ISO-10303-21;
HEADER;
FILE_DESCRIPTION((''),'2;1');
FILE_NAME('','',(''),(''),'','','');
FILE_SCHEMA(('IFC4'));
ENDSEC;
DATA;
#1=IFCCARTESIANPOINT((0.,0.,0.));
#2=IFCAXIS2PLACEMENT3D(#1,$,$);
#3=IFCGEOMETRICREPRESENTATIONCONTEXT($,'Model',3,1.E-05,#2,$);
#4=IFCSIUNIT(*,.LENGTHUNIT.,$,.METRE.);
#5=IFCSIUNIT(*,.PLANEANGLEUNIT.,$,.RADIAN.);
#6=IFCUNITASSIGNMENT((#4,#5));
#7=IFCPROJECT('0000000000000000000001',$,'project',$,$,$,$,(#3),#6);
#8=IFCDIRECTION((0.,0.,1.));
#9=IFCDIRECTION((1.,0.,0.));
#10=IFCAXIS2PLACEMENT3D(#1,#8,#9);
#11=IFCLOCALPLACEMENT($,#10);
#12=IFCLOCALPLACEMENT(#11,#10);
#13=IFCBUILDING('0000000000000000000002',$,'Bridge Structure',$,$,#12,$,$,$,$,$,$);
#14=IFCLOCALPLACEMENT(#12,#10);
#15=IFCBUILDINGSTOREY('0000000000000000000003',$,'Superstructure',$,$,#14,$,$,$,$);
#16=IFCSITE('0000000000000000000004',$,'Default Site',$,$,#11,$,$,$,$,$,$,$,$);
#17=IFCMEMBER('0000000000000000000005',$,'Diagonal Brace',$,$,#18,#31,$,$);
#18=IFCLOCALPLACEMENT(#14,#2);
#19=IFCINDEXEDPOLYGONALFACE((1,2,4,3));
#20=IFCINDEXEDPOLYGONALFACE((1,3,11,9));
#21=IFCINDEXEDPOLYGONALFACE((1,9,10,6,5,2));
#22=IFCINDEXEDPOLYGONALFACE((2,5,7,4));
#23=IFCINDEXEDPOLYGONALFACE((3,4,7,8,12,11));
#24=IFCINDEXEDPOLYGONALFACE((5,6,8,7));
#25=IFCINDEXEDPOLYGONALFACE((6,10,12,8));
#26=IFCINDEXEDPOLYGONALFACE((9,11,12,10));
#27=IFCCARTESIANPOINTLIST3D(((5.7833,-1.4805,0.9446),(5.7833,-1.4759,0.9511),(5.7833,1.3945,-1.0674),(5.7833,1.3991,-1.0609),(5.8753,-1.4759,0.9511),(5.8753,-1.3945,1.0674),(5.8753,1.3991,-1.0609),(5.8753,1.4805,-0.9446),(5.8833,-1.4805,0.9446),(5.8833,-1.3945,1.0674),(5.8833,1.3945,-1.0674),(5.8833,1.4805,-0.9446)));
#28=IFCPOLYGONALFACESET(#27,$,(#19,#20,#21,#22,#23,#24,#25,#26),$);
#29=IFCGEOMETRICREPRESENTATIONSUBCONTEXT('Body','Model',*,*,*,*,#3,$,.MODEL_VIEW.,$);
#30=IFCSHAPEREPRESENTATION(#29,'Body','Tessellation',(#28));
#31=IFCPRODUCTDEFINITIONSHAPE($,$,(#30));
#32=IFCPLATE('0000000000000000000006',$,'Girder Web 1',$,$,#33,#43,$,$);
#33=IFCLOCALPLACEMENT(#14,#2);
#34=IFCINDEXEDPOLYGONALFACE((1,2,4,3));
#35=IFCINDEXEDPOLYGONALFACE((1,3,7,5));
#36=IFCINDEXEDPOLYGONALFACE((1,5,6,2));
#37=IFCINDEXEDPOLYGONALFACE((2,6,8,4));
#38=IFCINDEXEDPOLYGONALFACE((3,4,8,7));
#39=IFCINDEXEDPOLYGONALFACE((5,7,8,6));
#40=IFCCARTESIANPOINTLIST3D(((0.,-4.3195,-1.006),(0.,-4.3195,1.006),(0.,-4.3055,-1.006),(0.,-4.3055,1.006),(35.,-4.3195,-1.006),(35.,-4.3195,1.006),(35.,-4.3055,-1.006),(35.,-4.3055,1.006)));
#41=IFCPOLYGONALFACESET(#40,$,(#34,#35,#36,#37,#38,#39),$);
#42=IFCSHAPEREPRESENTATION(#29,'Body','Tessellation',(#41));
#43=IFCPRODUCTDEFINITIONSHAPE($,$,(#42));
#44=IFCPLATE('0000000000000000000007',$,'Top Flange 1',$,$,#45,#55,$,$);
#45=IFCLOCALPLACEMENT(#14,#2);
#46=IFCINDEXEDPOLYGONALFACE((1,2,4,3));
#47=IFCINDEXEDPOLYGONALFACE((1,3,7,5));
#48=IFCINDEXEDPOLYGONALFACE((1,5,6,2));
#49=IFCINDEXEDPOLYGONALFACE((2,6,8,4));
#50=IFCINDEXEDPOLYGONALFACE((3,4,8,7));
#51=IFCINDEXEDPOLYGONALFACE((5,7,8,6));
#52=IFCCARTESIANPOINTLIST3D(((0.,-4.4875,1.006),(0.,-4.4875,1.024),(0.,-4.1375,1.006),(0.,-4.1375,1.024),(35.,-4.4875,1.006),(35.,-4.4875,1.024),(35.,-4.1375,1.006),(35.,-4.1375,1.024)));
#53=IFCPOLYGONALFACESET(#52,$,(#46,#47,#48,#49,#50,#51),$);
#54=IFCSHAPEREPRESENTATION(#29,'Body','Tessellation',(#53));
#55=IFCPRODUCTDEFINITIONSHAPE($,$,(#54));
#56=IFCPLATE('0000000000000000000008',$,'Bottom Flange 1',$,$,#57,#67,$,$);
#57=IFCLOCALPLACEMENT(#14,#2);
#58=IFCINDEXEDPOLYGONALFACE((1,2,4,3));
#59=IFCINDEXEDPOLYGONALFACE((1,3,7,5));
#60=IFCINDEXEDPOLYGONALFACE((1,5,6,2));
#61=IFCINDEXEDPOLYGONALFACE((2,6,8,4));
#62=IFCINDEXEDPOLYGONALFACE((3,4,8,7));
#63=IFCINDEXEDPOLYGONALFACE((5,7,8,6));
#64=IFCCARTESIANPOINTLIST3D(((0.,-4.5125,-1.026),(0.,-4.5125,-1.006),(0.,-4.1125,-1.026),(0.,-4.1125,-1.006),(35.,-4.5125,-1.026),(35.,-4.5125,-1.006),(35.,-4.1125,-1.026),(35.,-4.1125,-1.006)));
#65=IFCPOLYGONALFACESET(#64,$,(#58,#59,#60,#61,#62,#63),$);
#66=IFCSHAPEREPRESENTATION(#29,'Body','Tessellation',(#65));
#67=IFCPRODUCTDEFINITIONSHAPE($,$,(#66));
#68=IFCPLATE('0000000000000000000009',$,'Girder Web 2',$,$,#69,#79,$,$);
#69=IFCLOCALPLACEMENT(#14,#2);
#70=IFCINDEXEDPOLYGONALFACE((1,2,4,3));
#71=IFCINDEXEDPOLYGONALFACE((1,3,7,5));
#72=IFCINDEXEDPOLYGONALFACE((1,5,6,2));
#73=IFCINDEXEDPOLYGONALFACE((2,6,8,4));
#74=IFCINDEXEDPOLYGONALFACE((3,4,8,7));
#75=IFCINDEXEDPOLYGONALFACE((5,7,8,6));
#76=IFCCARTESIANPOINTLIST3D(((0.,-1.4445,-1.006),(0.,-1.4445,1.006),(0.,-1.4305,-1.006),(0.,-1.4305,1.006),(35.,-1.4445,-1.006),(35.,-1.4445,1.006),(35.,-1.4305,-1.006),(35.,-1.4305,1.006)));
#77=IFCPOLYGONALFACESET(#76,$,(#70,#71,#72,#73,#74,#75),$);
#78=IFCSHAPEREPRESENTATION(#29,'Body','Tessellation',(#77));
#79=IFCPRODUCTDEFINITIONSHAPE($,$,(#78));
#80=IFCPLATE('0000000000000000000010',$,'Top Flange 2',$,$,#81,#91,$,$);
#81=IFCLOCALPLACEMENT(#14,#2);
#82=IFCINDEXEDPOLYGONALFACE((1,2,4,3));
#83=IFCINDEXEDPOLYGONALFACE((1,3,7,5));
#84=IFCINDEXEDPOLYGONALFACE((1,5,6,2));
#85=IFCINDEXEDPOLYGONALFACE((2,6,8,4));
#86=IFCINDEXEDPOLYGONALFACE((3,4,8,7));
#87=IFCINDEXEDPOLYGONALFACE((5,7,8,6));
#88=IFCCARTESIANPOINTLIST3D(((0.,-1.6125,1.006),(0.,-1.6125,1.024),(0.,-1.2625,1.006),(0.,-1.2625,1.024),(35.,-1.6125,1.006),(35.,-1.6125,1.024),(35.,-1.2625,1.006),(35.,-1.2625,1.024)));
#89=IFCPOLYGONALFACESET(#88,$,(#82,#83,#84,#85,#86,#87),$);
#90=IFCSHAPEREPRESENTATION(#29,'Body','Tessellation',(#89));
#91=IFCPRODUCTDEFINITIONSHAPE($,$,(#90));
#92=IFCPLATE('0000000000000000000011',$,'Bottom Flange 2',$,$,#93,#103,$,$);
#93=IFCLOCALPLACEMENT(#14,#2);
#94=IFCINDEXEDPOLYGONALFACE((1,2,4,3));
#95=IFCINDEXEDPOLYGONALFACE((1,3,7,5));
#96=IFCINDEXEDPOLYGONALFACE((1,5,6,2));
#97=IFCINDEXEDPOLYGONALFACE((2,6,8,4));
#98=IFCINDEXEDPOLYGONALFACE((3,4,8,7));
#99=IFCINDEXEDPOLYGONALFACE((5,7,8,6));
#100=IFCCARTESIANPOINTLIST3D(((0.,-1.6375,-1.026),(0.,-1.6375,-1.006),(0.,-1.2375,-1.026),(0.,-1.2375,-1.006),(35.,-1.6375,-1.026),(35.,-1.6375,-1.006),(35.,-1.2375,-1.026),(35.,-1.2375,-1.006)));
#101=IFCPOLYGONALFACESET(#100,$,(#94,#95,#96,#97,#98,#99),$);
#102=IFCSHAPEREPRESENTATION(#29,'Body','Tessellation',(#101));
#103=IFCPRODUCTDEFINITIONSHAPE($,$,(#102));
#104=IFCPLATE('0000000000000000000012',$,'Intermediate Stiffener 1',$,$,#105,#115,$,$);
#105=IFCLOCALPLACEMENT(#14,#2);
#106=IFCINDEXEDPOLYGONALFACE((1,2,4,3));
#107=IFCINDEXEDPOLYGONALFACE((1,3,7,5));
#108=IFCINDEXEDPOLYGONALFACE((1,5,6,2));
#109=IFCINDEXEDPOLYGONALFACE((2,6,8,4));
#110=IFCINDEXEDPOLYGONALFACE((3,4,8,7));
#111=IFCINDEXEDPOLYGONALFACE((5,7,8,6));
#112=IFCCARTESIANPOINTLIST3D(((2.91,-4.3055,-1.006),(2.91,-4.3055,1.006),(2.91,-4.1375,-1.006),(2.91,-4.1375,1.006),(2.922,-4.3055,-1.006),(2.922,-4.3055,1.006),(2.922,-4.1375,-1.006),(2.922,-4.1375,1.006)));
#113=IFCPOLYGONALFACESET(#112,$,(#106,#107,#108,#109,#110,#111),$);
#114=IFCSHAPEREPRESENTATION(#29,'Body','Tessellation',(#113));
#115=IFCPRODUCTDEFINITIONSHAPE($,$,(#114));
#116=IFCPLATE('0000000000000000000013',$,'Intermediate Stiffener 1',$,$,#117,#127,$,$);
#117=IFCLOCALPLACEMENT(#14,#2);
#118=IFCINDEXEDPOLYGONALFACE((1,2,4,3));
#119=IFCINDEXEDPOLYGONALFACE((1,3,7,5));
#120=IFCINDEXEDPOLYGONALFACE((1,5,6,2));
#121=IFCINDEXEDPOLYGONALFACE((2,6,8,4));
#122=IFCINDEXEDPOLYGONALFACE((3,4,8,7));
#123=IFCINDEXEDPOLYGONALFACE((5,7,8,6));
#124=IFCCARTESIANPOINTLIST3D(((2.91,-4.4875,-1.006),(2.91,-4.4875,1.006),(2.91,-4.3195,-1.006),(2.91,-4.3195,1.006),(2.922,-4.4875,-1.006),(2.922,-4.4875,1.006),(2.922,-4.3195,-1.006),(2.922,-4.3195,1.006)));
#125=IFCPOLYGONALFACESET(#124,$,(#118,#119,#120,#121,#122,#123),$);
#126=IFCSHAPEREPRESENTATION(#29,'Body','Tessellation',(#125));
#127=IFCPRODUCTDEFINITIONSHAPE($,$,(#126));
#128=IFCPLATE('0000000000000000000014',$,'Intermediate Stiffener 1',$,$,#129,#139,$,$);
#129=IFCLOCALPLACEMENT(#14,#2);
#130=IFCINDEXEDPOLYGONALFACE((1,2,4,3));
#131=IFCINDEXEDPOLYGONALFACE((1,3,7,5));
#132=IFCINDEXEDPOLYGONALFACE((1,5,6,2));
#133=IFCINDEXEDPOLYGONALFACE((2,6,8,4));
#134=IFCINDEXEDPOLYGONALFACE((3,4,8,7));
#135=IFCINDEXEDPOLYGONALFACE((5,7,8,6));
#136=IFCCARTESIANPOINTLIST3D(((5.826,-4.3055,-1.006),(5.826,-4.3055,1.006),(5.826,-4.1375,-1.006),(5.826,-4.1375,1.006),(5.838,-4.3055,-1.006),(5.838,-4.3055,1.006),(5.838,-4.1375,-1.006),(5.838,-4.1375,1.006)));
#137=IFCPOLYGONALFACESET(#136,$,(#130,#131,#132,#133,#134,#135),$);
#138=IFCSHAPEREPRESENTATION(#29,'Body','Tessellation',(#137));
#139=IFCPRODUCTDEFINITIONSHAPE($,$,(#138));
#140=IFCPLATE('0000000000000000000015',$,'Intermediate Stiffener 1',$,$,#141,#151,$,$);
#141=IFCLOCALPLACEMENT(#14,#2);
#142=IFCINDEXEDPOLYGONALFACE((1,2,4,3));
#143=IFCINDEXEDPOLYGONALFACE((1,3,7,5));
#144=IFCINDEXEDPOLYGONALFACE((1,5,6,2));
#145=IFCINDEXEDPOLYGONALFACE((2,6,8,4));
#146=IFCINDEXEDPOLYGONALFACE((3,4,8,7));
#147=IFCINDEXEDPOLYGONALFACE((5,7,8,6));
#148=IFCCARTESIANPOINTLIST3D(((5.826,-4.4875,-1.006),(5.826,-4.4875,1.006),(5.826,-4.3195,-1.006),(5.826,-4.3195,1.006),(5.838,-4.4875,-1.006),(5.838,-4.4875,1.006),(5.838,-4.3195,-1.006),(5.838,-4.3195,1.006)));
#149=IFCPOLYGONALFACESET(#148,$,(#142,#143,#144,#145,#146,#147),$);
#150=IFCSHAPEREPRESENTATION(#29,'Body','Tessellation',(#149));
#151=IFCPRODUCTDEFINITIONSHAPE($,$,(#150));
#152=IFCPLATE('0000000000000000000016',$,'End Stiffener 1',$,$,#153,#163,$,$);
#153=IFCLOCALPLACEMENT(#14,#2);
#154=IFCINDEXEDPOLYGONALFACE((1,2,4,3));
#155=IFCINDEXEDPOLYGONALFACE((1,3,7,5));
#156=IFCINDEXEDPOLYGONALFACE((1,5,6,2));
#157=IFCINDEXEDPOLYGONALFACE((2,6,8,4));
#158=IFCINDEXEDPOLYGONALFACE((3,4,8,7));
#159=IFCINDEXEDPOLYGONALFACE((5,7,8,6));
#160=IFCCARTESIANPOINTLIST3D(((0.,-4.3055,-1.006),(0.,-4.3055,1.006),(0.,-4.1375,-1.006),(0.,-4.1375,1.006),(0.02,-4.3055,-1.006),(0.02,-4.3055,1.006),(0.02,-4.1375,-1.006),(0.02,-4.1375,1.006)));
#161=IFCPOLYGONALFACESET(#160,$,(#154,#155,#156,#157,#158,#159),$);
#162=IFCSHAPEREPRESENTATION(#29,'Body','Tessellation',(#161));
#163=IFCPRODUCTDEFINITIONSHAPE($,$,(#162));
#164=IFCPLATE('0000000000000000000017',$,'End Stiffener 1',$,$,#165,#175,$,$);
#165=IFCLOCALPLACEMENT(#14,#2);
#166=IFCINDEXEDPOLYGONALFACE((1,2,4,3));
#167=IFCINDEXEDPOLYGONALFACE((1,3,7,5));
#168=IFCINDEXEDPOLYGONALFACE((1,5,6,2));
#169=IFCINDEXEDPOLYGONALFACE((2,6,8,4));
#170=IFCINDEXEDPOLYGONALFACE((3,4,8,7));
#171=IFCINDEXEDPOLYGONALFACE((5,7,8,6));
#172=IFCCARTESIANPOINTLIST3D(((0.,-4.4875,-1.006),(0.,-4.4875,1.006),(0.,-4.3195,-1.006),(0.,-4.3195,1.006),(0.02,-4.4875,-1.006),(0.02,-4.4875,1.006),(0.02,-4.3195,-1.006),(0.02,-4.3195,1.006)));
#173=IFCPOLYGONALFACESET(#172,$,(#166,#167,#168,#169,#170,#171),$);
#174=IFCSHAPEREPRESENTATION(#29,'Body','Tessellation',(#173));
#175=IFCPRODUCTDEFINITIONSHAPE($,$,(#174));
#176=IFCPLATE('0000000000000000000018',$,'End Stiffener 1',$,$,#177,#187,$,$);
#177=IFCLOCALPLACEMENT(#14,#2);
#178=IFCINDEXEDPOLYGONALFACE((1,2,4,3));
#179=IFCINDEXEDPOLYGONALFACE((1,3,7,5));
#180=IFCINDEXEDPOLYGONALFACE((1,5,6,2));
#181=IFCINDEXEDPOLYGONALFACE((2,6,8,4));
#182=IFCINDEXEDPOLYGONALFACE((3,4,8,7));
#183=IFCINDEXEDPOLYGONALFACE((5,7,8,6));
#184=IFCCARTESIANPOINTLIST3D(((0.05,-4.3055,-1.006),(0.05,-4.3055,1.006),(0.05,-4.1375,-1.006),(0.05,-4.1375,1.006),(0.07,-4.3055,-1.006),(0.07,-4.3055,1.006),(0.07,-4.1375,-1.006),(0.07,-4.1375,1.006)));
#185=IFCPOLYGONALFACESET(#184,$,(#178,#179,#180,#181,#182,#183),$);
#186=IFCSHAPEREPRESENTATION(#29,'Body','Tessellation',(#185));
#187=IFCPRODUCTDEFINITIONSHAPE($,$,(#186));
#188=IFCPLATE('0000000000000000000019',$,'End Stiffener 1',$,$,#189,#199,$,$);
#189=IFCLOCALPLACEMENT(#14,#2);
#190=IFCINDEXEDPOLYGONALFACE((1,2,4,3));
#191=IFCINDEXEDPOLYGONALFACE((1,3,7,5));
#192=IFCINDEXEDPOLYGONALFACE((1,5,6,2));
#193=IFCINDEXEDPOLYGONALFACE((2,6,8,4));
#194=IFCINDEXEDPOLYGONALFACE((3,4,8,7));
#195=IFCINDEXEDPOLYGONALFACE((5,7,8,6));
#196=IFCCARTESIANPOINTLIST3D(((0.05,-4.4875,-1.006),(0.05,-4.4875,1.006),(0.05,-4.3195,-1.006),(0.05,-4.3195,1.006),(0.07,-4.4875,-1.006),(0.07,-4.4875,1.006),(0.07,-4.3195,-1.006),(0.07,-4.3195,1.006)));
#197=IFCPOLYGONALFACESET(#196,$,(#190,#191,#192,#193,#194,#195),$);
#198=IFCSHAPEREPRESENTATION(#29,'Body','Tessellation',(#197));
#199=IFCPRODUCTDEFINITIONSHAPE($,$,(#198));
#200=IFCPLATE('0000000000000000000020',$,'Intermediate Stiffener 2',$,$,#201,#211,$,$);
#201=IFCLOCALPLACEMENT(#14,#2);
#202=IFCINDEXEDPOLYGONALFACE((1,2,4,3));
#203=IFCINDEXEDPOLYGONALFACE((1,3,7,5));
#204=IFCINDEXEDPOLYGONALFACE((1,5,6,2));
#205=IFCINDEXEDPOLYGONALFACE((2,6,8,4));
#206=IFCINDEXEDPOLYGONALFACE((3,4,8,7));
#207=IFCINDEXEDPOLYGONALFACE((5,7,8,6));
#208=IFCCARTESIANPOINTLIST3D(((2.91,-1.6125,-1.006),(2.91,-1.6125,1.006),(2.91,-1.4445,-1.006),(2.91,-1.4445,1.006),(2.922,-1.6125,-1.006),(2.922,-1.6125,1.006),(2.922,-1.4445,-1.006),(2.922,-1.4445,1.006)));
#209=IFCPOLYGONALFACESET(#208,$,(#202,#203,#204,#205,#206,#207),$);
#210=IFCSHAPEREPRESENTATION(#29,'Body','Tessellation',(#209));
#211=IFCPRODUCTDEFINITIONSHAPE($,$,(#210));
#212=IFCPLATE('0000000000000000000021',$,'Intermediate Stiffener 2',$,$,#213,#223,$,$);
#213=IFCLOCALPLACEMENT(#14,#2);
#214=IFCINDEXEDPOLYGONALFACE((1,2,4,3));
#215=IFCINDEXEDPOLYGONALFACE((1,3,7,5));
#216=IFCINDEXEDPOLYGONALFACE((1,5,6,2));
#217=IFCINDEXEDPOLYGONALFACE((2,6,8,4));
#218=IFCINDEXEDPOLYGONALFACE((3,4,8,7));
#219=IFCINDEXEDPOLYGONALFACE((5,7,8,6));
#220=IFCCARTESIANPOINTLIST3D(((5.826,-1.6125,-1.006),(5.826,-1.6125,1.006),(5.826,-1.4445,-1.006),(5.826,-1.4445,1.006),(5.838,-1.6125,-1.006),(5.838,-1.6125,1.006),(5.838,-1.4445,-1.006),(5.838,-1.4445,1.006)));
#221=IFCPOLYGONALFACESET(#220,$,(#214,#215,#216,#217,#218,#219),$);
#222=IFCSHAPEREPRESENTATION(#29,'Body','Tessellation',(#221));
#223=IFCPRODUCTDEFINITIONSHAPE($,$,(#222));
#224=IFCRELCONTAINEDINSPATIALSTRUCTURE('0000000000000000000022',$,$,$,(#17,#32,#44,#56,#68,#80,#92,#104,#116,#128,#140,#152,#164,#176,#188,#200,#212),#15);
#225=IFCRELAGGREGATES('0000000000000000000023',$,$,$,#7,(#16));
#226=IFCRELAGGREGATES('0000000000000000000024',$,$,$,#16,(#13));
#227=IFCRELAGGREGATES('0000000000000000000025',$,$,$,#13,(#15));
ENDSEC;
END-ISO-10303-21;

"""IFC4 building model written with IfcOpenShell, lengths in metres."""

from ifc_helpers import new_model, si_unit, frame, origin, origin_with_axes, origin_2d_with_axis, place, context, subcontext, project, spatial, rectangle, l_section, extrude, element, save


model = new_model("IFC4")

# Units and contexts
model_context = context("Model", 3, precision=1e-05, world=origin())
body_context = subcontext(model_context, "Body", "Model", "MODEL_VIEW")
ifc_project = project(units=[si_unit("LENGTHUNIT", "METRE"), si_unit("PLANEANGLEUNIT", "RADIAN")], contexts=[model_context])

# Site, building, storey
site_placement = place(None, origin_with_axes())
site = spatial("IfcSite", under=ifc_project, at=site_placement, Name="Default Site")
building_placement = place(site_placement, origin_with_axes())
building = spatial("IfcBuilding", under=site, at=building_placement, Name="Bridge Structure")
storey_placement = place(building_placement, origin_with_axes())
storey = spatial("IfcBuildingStorey", under=building, at=storey_placement, Name="Superstructure")

# Member
member_placement = place(storey_placement, frame((5.8333, -1.4375, 1.006), z_axis=(0.0, 0.819299, -0.573367), x_axis=(-1.0, 0.0, 0.0)))
element("IfcMember", 1, at=member_placement, inside=storey, Name="Diagonal Brace", context=body_context, shape_type="SweptSolid", body=[
    extrude(l_section(Depth=0.15, Width=0.1, Thickness=0.008, at=origin_2d_with_axis()), origin_with_axes(), (0.0, 0.0, 1.0), 3.5091),
])

# Plates
plate_1_placement = place(storey_placement, frame((0.0, -4.3125, 0.0), z_axis=(1.0, 0.0, 0.0), x_axis=(0.0, 1.0, 0.0)))
element("IfcPlate", 2, at=plate_1_placement, inside=storey, Name="Girder Web 1", context=body_context, shape_type="SweptSolid", body=[
    extrude(rectangle(XDim=0.014, YDim=2.012, at=origin_2d_with_axis()), origin_with_axes(), (0.0, 0.0, 1.0), 35.0),
])
plate_2_placement = place(storey_placement, frame((0.0, -4.3125, 1.015), z_axis=(1.0, 0.0, 0.0), x_axis=(0.0, 1.0, 0.0)))
element("IfcPlate", 3, at=plate_2_placement, inside=storey, Name="Top Flange 1", context=body_context, shape_type="SweptSolid", body=[
    extrude(rectangle(XDim=0.35, YDim=0.018, at=origin_2d_with_axis()), origin_with_axes(), (0.0, 0.0, 1.0), 35.0),
])
plate_3_placement = place(storey_placement, frame((0.0, -4.3125, -1.016), z_axis=(1.0, 0.0, 0.0), x_axis=(0.0, 1.0, 0.0)))
element("IfcPlate", 4, at=plate_3_placement, inside=storey, Name="Bottom Flange 1", context=body_context, shape_type="SweptSolid", body=[
    extrude(rectangle(XDim=0.4, YDim=0.02, at=origin_2d_with_axis()), origin_with_axes(), (0.0, 0.0, 1.0), 35.0),
])
plate_4_placement = place(storey_placement, frame((0.0, -1.4375, 0.0), z_axis=(1.0, 0.0, 0.0), x_axis=(0.0, 1.0, 0.0)))
element("IfcPlate", 5, at=plate_4_placement, inside=storey, Name="Girder Web 2", context=body_context, shape_type="SweptSolid", body=[
    extrude(rectangle(XDim=0.014, YDim=2.012, at=origin_2d_with_axis()), origin_with_axes(), (0.0, 0.0, 1.0), 35.0),
])
plate_5_placement = place(storey_placement, frame((0.0, -1.4375, 1.015), z_axis=(1.0, 0.0, 0.0), x_axis=(0.0, 1.0, 0.0)))
element("IfcPlate", 6, at=plate_5_placement, inside=storey, Name="Top Flange 2", context=body_context, shape_type="SweptSolid", body=[
    extrude(rectangle(XDim=0.35, YDim=0.018, at=origin_2d_with_axis()), origin_with_axes(), (0.0, 0.0, 1.0), 35.0),
])
plate_6_placement = place(storey_placement, frame((0.0, -1.4375, -1.016), z_axis=(1.0, 0.0, 0.0), x_axis=(0.0, 1.0, 0.0)))
element("IfcPlate", 7, at=plate_6_placement, inside=storey, Name="Bottom Flange 2", context=body_context, shape_type="SweptSolid", body=[
    extrude(rectangle(XDim=0.4, YDim=0.02, at=origin_2d_with_axis()), origin_with_axes(), (0.0, 0.0, 1.0), 35.0),
])
for number, where, z_axis, x_axis, name in (
    (8, (2.916, -4.2215, -1.006), (0.0, 0.0, 1.0), (1.0, 0.0, 0.0), "Intermediate Stiffener 1"),
    (9, (2.916, -4.4035, -1.006), (0.0, 0.0, 1.0), (1.0, 0.0, 0.0), "Intermediate Stiffener 1"),
    (10, (5.832, -4.2215, -1.006), (0.0, 0.0, 1.0), (1.0, 0.0, 0.0), "Intermediate Stiffener 1"),
    (11, (5.832, -4.4035, -1.006), (0.0, 0.0, 1.0), (1.0, 0.0, 0.0), "Intermediate Stiffener 1"),
):
    element("IfcPlate", number, at=place(storey_placement, frame(where, z_axis=z_axis, x_axis=x_axis)), inside=storey, Name=name, context=body_context, shape_type="SweptSolid", body=[
        extrude(rectangle(XDim=0.012, YDim=0.168, at=origin_2d_with_axis()), origin_with_axes(), (0.0, 0.0, 1.0), 2.012),
    ])
for number, where, z_axis, x_axis, name in (
    (12, (0.01, -4.2215, -1.006), (0.0, 0.0, 1.0), (1.0, 0.0, 0.0), "End Stiffener 1"),
    (13, (0.01, -4.4035, -1.006), (0.0, 0.0, 1.0), (1.0, 0.0, 0.0), "End Stiffener 1"),
    (14, (0.06, -4.2215, -1.006), (0.0, 0.0, 1.0), (1.0, 0.0, 0.0), "End Stiffener 1"),
    (15, (0.06, -4.4035, -1.006), (0.0, 0.0, 1.0), (1.0, 0.0, 0.0), "End Stiffener 1"),
):
    element("IfcPlate", number, at=place(storey_placement, frame(where, z_axis=z_axis, x_axis=x_axis)), inside=storey, Name=name, context=body_context, shape_type="SweptSolid", body=[
        extrude(rectangle(XDim=0.02, YDim=0.168, at=origin_2d_with_axis()), origin_with_axes(), (0.0, 0.0, 1.0), 2.012),
    ])
for number, where, z_axis, x_axis, name in (
    (16, (2.916, -1.5285, -1.006), (0.0, 0.0, 1.0), (1.0, 0.0, 0.0), "Intermediate Stiffener 2"),
    (17, (5.832, -1.5285, -1.006), (0.0, 0.0, 1.0), (1.0, 0.0, 0.0), "Intermediate Stiffener 2"),
):
    element("IfcPlate", number, at=place(storey_placement, frame(where, z_axis=z_axis, x_axis=x_axis)), inside=storey, Name=name, context=body_context, shape_type="SweptSolid", body=[
        extrude(rectangle(XDim=0.012, YDim=0.168, at=origin_2d_with_axis()), origin_with_axes(), (0.0, 0.0, 1.0), 2.012),
    ])

save(model, "model.ifc")
